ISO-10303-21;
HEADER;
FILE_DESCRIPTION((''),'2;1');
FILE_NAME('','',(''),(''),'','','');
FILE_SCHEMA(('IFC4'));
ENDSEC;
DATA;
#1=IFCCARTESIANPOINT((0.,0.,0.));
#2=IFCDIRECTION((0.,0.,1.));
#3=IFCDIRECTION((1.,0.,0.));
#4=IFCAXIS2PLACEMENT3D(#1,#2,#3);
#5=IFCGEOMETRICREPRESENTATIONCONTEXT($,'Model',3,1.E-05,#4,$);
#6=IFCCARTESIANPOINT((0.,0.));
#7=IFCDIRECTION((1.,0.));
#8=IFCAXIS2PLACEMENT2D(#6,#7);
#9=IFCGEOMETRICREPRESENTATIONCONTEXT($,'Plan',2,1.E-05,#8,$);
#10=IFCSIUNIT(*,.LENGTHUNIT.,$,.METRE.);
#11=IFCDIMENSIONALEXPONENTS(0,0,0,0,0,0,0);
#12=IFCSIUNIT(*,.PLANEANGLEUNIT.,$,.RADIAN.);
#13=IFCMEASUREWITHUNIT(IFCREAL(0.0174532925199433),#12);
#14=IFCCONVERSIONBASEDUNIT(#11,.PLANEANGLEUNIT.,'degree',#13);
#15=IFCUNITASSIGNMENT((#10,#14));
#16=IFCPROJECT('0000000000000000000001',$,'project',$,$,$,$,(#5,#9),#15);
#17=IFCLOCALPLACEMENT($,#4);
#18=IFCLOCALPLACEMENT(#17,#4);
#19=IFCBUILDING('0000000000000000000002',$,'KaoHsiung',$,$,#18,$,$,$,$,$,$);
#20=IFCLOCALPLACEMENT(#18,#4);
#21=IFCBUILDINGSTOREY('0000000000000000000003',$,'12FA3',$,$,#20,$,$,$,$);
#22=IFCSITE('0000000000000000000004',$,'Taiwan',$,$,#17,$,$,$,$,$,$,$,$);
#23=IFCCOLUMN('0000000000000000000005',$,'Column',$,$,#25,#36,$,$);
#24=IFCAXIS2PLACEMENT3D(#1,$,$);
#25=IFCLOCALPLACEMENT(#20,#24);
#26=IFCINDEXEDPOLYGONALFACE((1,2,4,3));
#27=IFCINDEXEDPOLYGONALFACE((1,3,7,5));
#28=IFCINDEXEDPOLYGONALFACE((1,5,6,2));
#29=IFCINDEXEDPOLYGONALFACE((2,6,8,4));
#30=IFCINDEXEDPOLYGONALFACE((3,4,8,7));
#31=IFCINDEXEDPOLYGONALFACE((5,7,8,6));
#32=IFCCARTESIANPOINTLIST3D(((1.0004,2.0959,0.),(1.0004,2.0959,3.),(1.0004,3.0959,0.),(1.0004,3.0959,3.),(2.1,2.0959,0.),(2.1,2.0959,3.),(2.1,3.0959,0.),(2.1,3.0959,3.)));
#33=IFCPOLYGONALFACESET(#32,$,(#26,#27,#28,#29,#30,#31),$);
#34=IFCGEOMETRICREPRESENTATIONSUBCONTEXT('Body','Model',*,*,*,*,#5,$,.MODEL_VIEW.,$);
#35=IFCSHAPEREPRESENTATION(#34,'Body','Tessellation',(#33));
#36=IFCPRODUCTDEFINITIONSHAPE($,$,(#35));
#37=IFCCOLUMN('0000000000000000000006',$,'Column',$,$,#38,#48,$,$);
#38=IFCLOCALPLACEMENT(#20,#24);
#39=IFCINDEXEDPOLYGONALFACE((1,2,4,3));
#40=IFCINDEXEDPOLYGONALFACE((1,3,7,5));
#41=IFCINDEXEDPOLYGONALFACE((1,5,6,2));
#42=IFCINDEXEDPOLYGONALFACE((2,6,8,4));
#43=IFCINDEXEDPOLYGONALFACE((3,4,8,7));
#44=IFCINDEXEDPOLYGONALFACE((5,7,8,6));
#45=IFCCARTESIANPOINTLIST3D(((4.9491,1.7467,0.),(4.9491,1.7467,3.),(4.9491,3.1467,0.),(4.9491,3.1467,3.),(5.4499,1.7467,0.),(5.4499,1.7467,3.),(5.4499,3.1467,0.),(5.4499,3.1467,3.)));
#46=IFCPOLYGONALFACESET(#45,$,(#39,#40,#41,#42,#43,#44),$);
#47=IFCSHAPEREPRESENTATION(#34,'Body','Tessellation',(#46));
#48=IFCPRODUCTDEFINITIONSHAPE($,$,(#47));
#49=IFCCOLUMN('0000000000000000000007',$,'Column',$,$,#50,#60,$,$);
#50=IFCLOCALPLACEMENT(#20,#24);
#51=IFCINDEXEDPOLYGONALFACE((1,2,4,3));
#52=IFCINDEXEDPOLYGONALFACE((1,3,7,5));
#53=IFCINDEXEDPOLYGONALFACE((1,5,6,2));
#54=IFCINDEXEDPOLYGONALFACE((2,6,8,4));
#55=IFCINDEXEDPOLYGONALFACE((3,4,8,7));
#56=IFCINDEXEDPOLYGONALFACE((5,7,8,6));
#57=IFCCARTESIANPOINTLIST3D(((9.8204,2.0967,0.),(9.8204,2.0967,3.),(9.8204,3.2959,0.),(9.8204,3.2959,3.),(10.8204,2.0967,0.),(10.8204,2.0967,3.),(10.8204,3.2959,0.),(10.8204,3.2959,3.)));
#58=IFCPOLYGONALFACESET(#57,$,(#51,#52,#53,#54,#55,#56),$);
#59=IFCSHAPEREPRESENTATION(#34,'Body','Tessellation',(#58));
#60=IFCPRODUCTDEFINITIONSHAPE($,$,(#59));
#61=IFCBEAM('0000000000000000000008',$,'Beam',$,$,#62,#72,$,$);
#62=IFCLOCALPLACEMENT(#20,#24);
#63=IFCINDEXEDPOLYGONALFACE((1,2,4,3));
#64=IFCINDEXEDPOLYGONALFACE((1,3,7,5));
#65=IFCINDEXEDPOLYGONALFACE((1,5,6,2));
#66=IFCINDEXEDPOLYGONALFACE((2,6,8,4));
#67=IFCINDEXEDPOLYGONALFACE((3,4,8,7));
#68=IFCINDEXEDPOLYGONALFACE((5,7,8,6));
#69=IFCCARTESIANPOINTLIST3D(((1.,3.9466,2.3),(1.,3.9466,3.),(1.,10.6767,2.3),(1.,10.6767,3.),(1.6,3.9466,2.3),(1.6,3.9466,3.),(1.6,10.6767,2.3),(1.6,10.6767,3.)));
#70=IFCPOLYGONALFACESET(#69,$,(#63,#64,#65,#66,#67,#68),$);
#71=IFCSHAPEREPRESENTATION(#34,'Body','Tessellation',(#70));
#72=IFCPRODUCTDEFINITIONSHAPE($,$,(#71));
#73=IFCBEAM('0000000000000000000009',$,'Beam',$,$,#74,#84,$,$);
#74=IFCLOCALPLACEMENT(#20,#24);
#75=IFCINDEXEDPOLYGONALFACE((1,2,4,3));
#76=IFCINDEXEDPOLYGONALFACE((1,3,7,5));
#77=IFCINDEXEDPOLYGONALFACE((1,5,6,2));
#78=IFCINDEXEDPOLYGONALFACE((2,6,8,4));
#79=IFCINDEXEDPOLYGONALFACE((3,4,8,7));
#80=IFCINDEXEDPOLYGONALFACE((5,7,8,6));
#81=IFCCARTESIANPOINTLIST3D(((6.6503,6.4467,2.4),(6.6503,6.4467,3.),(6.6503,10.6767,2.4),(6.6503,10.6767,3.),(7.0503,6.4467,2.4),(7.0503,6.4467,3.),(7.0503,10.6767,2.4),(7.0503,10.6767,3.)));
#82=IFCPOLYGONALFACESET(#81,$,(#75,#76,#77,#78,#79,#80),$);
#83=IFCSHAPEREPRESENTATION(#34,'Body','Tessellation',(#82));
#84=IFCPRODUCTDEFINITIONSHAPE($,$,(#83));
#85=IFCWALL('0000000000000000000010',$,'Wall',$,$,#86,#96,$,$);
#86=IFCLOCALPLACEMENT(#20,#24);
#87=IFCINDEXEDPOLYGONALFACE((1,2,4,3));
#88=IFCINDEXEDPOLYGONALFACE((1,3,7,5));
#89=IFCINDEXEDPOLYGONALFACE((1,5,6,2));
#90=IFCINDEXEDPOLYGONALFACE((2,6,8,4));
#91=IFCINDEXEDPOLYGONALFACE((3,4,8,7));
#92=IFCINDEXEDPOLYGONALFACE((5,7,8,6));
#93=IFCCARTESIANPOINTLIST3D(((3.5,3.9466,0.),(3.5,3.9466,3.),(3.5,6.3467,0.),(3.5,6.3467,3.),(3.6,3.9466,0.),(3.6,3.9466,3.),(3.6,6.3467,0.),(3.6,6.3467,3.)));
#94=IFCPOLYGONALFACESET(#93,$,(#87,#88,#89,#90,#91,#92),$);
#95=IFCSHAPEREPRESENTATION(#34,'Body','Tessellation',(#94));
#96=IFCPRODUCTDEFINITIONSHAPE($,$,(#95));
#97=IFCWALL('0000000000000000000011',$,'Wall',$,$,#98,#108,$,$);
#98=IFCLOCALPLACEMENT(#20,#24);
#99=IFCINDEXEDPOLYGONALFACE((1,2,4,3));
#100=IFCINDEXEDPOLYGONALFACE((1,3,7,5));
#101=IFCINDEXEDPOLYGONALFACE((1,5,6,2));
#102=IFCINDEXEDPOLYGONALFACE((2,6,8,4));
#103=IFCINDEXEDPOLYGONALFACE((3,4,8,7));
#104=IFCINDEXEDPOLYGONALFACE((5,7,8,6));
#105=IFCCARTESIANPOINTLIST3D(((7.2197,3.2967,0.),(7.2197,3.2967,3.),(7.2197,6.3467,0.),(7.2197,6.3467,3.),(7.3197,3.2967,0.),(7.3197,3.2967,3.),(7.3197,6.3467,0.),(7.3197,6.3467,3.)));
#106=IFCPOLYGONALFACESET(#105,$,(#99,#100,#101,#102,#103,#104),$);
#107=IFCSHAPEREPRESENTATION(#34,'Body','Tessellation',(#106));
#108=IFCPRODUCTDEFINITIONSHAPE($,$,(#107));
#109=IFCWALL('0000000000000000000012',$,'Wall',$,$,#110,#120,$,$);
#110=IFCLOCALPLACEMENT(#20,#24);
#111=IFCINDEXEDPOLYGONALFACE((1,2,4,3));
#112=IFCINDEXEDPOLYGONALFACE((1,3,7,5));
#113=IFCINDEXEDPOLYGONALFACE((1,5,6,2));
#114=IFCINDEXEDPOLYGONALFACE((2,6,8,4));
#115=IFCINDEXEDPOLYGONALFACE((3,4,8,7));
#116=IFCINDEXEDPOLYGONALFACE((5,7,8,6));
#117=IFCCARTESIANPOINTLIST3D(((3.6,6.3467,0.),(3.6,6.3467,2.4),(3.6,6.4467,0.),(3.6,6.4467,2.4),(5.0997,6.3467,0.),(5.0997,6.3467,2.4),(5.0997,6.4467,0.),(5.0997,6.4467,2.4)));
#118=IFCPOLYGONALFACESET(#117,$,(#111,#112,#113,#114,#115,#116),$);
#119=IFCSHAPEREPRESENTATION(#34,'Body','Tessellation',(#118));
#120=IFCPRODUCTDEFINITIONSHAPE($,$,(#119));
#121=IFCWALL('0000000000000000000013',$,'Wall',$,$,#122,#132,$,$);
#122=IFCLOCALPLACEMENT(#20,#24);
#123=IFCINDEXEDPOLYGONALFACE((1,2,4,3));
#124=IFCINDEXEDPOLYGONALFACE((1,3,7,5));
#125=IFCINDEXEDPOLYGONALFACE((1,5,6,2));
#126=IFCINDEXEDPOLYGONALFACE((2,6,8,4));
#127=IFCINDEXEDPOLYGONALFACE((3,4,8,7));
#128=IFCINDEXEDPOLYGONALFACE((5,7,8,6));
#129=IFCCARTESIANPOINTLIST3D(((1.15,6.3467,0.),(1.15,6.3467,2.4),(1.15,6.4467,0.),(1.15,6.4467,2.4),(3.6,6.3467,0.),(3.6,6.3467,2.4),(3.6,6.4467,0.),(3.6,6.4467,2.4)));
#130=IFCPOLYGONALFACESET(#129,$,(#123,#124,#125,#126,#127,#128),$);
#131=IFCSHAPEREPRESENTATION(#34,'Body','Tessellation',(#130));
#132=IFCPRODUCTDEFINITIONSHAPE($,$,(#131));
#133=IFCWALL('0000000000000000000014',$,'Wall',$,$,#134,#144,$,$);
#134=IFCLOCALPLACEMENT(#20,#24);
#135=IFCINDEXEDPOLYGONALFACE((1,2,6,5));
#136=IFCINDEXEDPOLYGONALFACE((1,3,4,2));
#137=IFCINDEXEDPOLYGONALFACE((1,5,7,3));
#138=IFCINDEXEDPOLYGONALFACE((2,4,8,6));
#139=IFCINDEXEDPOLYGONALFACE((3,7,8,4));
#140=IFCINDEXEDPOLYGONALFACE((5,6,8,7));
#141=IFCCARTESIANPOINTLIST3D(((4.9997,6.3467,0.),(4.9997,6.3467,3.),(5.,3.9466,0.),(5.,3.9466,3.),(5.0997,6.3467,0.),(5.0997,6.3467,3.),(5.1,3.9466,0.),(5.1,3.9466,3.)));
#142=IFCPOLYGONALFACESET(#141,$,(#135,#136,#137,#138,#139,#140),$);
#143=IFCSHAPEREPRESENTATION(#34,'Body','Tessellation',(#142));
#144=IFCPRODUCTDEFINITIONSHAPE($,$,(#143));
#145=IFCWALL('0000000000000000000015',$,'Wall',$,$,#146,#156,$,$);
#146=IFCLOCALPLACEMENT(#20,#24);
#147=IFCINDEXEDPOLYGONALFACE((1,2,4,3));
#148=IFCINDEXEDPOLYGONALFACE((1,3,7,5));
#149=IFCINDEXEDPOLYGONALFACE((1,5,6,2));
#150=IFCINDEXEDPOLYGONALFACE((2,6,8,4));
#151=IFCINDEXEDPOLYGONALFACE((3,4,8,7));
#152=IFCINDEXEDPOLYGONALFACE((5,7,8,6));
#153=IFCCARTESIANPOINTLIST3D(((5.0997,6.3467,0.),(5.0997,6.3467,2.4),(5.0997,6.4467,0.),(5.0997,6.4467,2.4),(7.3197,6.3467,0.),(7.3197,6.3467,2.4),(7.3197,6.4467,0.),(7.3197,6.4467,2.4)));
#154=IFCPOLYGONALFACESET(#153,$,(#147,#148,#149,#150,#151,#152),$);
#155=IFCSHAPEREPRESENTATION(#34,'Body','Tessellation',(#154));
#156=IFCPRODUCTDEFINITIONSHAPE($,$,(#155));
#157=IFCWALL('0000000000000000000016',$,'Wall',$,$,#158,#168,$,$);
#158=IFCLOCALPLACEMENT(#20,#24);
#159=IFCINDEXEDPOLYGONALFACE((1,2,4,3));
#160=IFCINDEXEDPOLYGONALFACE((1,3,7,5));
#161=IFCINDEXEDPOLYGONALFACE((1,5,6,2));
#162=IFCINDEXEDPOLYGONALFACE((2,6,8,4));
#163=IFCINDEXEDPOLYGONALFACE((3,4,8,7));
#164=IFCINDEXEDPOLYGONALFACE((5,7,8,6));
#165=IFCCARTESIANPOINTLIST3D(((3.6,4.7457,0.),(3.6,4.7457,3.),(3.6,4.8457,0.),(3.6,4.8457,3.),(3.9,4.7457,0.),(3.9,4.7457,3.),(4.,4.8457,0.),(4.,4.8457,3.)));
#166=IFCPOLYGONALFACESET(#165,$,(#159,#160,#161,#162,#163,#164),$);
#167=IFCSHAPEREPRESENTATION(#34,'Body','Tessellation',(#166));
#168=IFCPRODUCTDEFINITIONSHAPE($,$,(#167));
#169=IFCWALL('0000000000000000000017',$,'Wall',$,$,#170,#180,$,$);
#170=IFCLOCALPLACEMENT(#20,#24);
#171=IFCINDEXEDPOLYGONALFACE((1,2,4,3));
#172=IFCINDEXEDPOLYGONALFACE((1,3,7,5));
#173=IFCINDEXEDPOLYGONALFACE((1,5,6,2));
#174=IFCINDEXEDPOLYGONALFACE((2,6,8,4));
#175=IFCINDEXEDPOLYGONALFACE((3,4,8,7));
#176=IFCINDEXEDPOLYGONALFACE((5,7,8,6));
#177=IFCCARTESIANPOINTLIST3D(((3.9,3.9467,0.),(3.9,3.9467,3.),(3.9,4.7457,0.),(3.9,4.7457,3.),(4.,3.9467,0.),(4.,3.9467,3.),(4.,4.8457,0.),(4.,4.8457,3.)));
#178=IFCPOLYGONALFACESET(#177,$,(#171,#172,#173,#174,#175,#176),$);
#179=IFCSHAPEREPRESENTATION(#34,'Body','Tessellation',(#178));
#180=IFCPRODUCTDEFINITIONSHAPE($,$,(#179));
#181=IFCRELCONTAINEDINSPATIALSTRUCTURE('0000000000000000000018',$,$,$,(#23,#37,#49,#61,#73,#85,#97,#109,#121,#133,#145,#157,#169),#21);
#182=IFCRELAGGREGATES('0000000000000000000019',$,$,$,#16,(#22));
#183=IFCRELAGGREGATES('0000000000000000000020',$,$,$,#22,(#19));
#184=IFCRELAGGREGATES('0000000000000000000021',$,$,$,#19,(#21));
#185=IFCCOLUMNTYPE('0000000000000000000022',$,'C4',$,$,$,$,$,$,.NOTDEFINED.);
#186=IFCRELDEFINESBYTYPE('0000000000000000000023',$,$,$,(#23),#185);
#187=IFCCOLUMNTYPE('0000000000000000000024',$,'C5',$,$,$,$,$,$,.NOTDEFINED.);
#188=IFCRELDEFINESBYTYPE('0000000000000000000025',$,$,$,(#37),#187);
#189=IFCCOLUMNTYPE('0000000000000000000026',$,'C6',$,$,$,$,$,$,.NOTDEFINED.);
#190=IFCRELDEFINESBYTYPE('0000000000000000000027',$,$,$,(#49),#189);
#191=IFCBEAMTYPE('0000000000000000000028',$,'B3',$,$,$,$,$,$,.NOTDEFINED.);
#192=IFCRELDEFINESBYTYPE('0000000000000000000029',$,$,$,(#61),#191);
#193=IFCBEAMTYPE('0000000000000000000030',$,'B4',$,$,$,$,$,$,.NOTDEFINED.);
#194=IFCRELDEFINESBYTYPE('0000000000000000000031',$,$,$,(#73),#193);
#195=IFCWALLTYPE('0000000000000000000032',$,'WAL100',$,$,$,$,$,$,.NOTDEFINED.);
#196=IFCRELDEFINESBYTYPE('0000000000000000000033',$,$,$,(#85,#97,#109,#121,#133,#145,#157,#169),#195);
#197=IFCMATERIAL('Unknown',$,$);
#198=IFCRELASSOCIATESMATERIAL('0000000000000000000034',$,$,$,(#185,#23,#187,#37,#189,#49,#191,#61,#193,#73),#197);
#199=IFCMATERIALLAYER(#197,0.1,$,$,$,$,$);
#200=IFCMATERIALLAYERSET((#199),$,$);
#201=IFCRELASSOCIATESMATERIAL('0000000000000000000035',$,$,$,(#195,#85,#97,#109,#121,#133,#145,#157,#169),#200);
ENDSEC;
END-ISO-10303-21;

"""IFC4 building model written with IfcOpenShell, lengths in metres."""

from ifc_helpers import new_model, entity, si_unit, converted_unit, frame, origin_with_axes, origin_2d_with_axis, place, context, subcontext, project, spatial, line, indexed_curve, rectangle, outline, extrude, material, layer, layer_set, layer_usage, material_profile, profile_set, profile_usage, type_object, element, save


model = new_model("IFC4")

# Units and contexts
model_context = context("Model", 3, precision=1e-05, world=origin_with_axes())
plan_context = context("Plan", 2, precision=1e-05, world=origin_2d_with_axis())
body_context = subcontext(model_context, "Body", "Model", "MODEL_VIEW")
ifc_project = project(units=[si_unit("LENGTHUNIT", "METRE"), converted_unit("PLANEANGLEUNIT", "degree", entity("IfcReal", 0.0174532925199433), si_unit("PLANEANGLEUNIT", "RADIAN"), dimensions=[0, 0, 0, 0, 0, 0, 0])], contexts=[model_context, plan_context])

# Site, building, storey
site_placement = place(None, origin_with_axes())
site = spatial("IfcSite", under=ifc_project, at=site_placement, Name="Taiwan")
building_placement = place(site_placement, origin_with_axes())
building = spatial("IfcBuilding", under=site, at=building_placement, Name="KaoHsiung")
storey_placement = place(building_placement, origin_with_axes())
storey = spatial("IfcBuildingStorey", under=building, at=storey_placement, Name="12FA3")

# Columns
ifc_material = material(Name="Unknown")
ifc_material_profile_1 = material_profile(ifc_material, outline(indexed_curve([(0.0, 1.0), (1.0995, 1.0), (1.0995, 0.0), (0.0, 0.0), (0.0, 1.0)])))
ifc_profile_set_1 = profile_set([ifc_material_profile_1])
ifc_profile_usage_1 = profile_usage(ifc_profile_set_1, cardinal=5)
column_type_1 = type_object("IfcColumnType", Name="C4", PredefinedType="NOTDEFINED", material=ifc_profile_set_1)
column_1_placement = place(storey_placement, frame((1.0004, 2.0959, 0.0), z_axis=(0.0, 0.0, 1.0), x_axis=(1.0, 0.0, 0.0)))
element("IfcColumn", 1, at=column_1_placement, inside=storey, type_object=column_type_1, material=ifc_profile_usage_1, Name="Column", context=body_context, shape_type="SweptSolid", body=[
    extrude(outline(indexed_curve([(0.0, 1.0), (1.0995, 1.0), (1.0995, 0.0), (0.0, 0.0), (0.0, 1.0)])), origin_with_axes(), (0.0, 0.0, 1.0), 3.0),
])
ifc_material_profile_2 = material_profile(ifc_material, outline(indexed_curve([(0.0, 0.0), (0.5008, 0.0), (0.5008, 1.4), (0.0, 1.4), (0.0, 0.0)])))
ifc_profile_set_2 = profile_set([ifc_material_profile_2])
ifc_profile_usage_2 = profile_usage(ifc_profile_set_2, cardinal=5)
column_type_2 = type_object("IfcColumnType", Name="C5", PredefinedType="NOTDEFINED", material=ifc_profile_set_2)
column_2_placement = place(storey_placement, frame((4.9491, 1.7467, 0.0), z_axis=(0.0, 0.0, 1.0), x_axis=(1.0, 0.0, 0.0)))
element("IfcColumn", 2, at=column_2_placement, inside=storey, type_object=column_type_2, material=ifc_profile_usage_2, Name="Column", context=body_context, shape_type="SweptSolid", body=[
    extrude(outline(indexed_curve([(0.0, 0.0), (0.5008, 0.0), (0.5008, 1.4), (0.0, 1.4), (0.0, 0.0)])), origin_with_axes(), (0.0, 0.0, 1.0), 3.0),
])
ifc_material_profile_3 = material_profile(ifc_material, outline(indexed_curve([(0.0, 1.1992), (1.0, 1.1992), (1.0, 0.0), (0.0, 0.0), (0.0, 1.1992)])))
ifc_profile_set_3 = profile_set([ifc_material_profile_3])
ifc_profile_usage_3 = profile_usage(ifc_profile_set_3, cardinal=5)
column_type_3 = type_object("IfcColumnType", Name="C6", PredefinedType="NOTDEFINED", material=ifc_profile_set_3)
column_3_placement = place(storey_placement, frame((9.8204, 2.0967, 0.0), z_axis=(0.0, 0.0, 1.0), x_axis=(1.0, 0.0, 0.0)))
element("IfcColumn", 3, at=column_3_placement, inside=storey, type_object=column_type_3, material=ifc_profile_usage_3, Name="Column", context=body_context, shape_type="SweptSolid", body=[
    extrude(outline(indexed_curve([(0.0, 1.1992), (1.0, 1.1992), (1.0, 0.0), (0.0, 0.0), (0.0, 1.1992)])), origin_with_axes(), (0.0, 0.0, 1.0), 3.0),
])

# Beams
ifc_material_profile_4 = material_profile(ifc_material, rectangle(XDim=0.6, YDim=0.7, kind="CURVE"))
ifc_profile_set_4 = profile_set([ifc_material_profile_4])
ifc_profile_usage_4 = profile_usage(ifc_profile_set_4, cardinal=7)
beam_type_1 = type_object("IfcBeamType", Name="B3", PredefinedType="NOTDEFINED", material=ifc_profile_set_4)
beam_1_placement = place(storey_placement, frame((1.0, 3.9466, 3.0), z_axis=(0.0, 1.0, 0.0), x_axis=(-1.0, 0.0, 0.0)))
element("IfcBeam", 4, at=beam_1_placement, inside=storey, type_object=beam_type_1, material=ifc_profile_usage_4, Name="Beam", context=body_context, shape_type="SweptSolid", body=[
    extrude(rectangle(XDim=0.6, YDim=0.7, kind="CURVE"), frame((-0.3, -0.35, 0.0), z_axis=(0.0, 0.0, 1.0), x_axis=(1.0, 0.0, 0.0)), (0.0, 0.0, 1.0), 6.7301),
])
ifc_material_profile_5 = material_profile(ifc_material, rectangle(XDim=0.4, YDim=0.6, kind="CURVE"))
ifc_profile_set_5 = profile_set([ifc_material_profile_5])
ifc_profile_usage_5 = profile_usage(ifc_profile_set_5, cardinal=7)
beam_type_2 = type_object("IfcBeamType", Name="B4", PredefinedType="NOTDEFINED", material=ifc_profile_set_5)
beam_2_placement = place(storey_placement, frame((6.6503, 6.4467, 3.0), z_axis=(0.0, 1.0, 0.0), x_axis=(-1.0, 0.0, 0.0)))
element("IfcBeam", 5, at=beam_2_placement, inside=storey, type_object=beam_type_2, material=ifc_profile_usage_5, Name="Beam", context=body_context, shape_type="SweptSolid", body=[
    extrude(rectangle(XDim=0.4, YDim=0.6, kind="CURVE"), frame((-0.2, -0.3, 0.0), z_axis=(0.0, 0.0, 1.0), x_axis=(1.0, 0.0, 0.0)), (0.0, 0.0, 1.0), 4.23),
])

# Walls
ifc_layer_1 = layer(ifc_material, 0.1)
ifc_layer_set_1 = layer_set([ifc_layer_1])
ifc_layer_usage_1 = layer_usage(ifc_layer_set_1, "AXIS2", "POSITIVE", 0.0)
wall_type_1 = type_object("IfcWallType", Name="WAL100", PredefinedType="NOTDEFINED", material=ifc_layer_set_1)
wall_1_placement = place(storey_placement, frame((3.6, 3.9466, 0.0), z_axis=(0.0, 0.0, 1.0), x_axis=(0.0, 1.0, 0.0)))
element("IfcWall", 6, at=wall_1_placement, inside=storey, type_object=wall_type_1, material=ifc_layer_usage_1, Name="Wall", context=body_context, shape_type="SweptSolid", body=[
    extrude(outline(indexed_curve([(0.0, 0.0), (0.0, 0.1), (2.4001, 0.1), (2.4001, 0.0)], segments=[line(1, 2, 3, 4, 1)])), origin_with_axes(), (0.0, 0.0, 1.0), 3.0),
])
ifc_layer_usage_2 = layer_usage(ifc_layer_set_1, "AXIS2", "POSITIVE", 0.0)
wall_2_placement = place(storey_placement, frame((7.3197, 3.2967, 0.0), z_axis=(0.0, 0.0, 1.0), x_axis=(0.0, 1.0, 0.0)))
element("IfcWall", 7, at=wall_2_placement, inside=storey, type_object=wall_type_1, material=ifc_layer_usage_2, Name="Wall", context=body_context, shape_type="SweptSolid", body=[
    extrude(outline(indexed_curve([(0.0, 0.0), (0.0, 0.1), (3.05, 0.1), (3.05, 0.0)], segments=[line(1, 2, 3, 4, 1)])), origin_with_axes(), (0.0, 0.0, 1.0), 3.0),
])
ifc_layer_usage_3 = layer_usage(ifc_layer_set_1, "AXIS2", "POSITIVE", 0.0)
wall_3_placement = place(storey_placement, frame((5.0997, 6.4467, 0.0), z_axis=(0.0, 0.0, 1.0), x_axis=(-1.0, 0.0, 0.0)))
element("IfcWall", 8, at=wall_3_placement, inside=storey, type_object=wall_type_1, material=ifc_layer_usage_3, Name="Wall", context=body_context, shape_type="SweptSolid", body=[
    extrude(outline(indexed_curve([(0.0, 0.0), (0.0, 0.1), (1.4997, 0.1), (1.4997, 0.0)], segments=[line(1, 2, 3, 4, 1)])), origin_with_axes(), (0.0, 0.0, 1.0), 2.4),
])
ifc_layer_usage_4 = layer_usage(ifc_layer_set_1, "AXIS2", "POSITIVE", 0.0)
wall_4_placement = place(storey_placement, frame((3.6, 6.4467, 0.0), z_axis=(0.0, 0.0, 1.0), x_axis=(-1.0, 0.0, 0.0)))
element("IfcWall", 9, at=wall_4_placement, inside=storey, type_object=wall_type_1, material=ifc_layer_usage_4, Name="Wall", context=body_context, shape_type="SweptSolid", body=[
    extrude(outline(indexed_curve([(0.0, 0.0), (0.0, 0.1), (2.45, 0.1), (2.45, 0.0)], segments=[line(1, 2, 3, 4, 1)])), origin_with_axes(), (0.0, 0.0, 1.0), 2.4),
])
ifc_layer_usage_5 = layer_usage(ifc_layer_set_1, "AXIS2", "POSITIVE", 0.0)
wall_5_placement = place(storey_placement, frame((4.9997, 6.3467, 0.0), z_axis=(0.0, 0.0, 1.0), x_axis=(0.000135, -1.0, 0.0)))
element("IfcWall", 10, at=wall_5_placement, inside=storey, type_object=wall_type_1, material=ifc_layer_usage_5, Name="Wall", context=body_context, shape_type="SweptSolid", body=[
    extrude(outline(indexed_curve([(0.0, 0.0), (0.0, 0.1), (2.4001, 0.1), (2.4001, 0.0)], segments=[line(1, 2, 3, 4, 1)])), origin_with_axes(), (0.0, 0.0, 1.0), 3.0),
])
ifc_layer_usage_6 = layer_usage(ifc_layer_set_1, "AXIS2", "POSITIVE", 0.0)
wall_6_placement = place(storey_placement, frame((7.3197, 6.4467, 0.0), z_axis=(0.0, 0.0, 1.0), x_axis=(-1.0, 0.0, 0.0)))
element("IfcWall", 11, at=wall_6_placement, inside=storey, type_object=wall_type_1, material=ifc_layer_usage_6, Name="Wall", context=body_context, shape_type="SweptSolid", body=[
    extrude(outline(indexed_curve([(0.0, 0.0), (0.0, 0.1), (2.22, 0.1), (2.22, 0.0)], segments=[line(1, 2, 3, 4, 1)])), origin_with_axes(), (0.0, 0.0, 1.0), 2.4),
])
ifc_layer_usage_7 = layer_usage(ifc_layer_set_1, "AXIS2", "POSITIVE", 0.0)
wall_7_placement = place(storey_placement, frame((3.6, 4.7457, 0.0), z_axis=(0.0, 0.0, 1.0), x_axis=(1.0, 0.0, 0.0)))
element("IfcWall", 12, at=wall_7_placement, inside=storey, type_object=wall_type_1, material=ifc_layer_usage_7, Name="Wall", context=body_context, shape_type="SweptSolid", body=[
    extrude(outline(indexed_curve([(0.0, 0.0), (0.0, 0.1), (0.4, 0.1), (0.3, 0.0)], segments=[line(1, 2, 3, 4, 1)])), origin_with_axes(), (0.0, 0.0, 1.0), 3.0),
])
ifc_layer_usage_8 = layer_usage(ifc_layer_set_1, "AXIS2", "POSITIVE", 0.0)
wall_8_placement = place(storey_placement, frame((3.9, 4.7457, 0.0), z_axis=(0.0, 0.0, 1.0), x_axis=(0.0, -1.0, 0.0)))
element("IfcWall", 13, at=wall_8_placement, inside=storey, type_object=wall_type_1, material=ifc_layer_usage_8, Name="Wall", context=body_context, shape_type="SweptSolid", body=[
    extrude(outline(indexed_curve([(0.0, 0.0), (-0.1, 0.1), (0.799, 0.1), (0.799, 0.0)], segments=[line(1, 2, 3, 4, 1)])), origin_with_axes(), (0.0, 0.0, 1.0), 3.0),
])

save(model, "model.ifc")
